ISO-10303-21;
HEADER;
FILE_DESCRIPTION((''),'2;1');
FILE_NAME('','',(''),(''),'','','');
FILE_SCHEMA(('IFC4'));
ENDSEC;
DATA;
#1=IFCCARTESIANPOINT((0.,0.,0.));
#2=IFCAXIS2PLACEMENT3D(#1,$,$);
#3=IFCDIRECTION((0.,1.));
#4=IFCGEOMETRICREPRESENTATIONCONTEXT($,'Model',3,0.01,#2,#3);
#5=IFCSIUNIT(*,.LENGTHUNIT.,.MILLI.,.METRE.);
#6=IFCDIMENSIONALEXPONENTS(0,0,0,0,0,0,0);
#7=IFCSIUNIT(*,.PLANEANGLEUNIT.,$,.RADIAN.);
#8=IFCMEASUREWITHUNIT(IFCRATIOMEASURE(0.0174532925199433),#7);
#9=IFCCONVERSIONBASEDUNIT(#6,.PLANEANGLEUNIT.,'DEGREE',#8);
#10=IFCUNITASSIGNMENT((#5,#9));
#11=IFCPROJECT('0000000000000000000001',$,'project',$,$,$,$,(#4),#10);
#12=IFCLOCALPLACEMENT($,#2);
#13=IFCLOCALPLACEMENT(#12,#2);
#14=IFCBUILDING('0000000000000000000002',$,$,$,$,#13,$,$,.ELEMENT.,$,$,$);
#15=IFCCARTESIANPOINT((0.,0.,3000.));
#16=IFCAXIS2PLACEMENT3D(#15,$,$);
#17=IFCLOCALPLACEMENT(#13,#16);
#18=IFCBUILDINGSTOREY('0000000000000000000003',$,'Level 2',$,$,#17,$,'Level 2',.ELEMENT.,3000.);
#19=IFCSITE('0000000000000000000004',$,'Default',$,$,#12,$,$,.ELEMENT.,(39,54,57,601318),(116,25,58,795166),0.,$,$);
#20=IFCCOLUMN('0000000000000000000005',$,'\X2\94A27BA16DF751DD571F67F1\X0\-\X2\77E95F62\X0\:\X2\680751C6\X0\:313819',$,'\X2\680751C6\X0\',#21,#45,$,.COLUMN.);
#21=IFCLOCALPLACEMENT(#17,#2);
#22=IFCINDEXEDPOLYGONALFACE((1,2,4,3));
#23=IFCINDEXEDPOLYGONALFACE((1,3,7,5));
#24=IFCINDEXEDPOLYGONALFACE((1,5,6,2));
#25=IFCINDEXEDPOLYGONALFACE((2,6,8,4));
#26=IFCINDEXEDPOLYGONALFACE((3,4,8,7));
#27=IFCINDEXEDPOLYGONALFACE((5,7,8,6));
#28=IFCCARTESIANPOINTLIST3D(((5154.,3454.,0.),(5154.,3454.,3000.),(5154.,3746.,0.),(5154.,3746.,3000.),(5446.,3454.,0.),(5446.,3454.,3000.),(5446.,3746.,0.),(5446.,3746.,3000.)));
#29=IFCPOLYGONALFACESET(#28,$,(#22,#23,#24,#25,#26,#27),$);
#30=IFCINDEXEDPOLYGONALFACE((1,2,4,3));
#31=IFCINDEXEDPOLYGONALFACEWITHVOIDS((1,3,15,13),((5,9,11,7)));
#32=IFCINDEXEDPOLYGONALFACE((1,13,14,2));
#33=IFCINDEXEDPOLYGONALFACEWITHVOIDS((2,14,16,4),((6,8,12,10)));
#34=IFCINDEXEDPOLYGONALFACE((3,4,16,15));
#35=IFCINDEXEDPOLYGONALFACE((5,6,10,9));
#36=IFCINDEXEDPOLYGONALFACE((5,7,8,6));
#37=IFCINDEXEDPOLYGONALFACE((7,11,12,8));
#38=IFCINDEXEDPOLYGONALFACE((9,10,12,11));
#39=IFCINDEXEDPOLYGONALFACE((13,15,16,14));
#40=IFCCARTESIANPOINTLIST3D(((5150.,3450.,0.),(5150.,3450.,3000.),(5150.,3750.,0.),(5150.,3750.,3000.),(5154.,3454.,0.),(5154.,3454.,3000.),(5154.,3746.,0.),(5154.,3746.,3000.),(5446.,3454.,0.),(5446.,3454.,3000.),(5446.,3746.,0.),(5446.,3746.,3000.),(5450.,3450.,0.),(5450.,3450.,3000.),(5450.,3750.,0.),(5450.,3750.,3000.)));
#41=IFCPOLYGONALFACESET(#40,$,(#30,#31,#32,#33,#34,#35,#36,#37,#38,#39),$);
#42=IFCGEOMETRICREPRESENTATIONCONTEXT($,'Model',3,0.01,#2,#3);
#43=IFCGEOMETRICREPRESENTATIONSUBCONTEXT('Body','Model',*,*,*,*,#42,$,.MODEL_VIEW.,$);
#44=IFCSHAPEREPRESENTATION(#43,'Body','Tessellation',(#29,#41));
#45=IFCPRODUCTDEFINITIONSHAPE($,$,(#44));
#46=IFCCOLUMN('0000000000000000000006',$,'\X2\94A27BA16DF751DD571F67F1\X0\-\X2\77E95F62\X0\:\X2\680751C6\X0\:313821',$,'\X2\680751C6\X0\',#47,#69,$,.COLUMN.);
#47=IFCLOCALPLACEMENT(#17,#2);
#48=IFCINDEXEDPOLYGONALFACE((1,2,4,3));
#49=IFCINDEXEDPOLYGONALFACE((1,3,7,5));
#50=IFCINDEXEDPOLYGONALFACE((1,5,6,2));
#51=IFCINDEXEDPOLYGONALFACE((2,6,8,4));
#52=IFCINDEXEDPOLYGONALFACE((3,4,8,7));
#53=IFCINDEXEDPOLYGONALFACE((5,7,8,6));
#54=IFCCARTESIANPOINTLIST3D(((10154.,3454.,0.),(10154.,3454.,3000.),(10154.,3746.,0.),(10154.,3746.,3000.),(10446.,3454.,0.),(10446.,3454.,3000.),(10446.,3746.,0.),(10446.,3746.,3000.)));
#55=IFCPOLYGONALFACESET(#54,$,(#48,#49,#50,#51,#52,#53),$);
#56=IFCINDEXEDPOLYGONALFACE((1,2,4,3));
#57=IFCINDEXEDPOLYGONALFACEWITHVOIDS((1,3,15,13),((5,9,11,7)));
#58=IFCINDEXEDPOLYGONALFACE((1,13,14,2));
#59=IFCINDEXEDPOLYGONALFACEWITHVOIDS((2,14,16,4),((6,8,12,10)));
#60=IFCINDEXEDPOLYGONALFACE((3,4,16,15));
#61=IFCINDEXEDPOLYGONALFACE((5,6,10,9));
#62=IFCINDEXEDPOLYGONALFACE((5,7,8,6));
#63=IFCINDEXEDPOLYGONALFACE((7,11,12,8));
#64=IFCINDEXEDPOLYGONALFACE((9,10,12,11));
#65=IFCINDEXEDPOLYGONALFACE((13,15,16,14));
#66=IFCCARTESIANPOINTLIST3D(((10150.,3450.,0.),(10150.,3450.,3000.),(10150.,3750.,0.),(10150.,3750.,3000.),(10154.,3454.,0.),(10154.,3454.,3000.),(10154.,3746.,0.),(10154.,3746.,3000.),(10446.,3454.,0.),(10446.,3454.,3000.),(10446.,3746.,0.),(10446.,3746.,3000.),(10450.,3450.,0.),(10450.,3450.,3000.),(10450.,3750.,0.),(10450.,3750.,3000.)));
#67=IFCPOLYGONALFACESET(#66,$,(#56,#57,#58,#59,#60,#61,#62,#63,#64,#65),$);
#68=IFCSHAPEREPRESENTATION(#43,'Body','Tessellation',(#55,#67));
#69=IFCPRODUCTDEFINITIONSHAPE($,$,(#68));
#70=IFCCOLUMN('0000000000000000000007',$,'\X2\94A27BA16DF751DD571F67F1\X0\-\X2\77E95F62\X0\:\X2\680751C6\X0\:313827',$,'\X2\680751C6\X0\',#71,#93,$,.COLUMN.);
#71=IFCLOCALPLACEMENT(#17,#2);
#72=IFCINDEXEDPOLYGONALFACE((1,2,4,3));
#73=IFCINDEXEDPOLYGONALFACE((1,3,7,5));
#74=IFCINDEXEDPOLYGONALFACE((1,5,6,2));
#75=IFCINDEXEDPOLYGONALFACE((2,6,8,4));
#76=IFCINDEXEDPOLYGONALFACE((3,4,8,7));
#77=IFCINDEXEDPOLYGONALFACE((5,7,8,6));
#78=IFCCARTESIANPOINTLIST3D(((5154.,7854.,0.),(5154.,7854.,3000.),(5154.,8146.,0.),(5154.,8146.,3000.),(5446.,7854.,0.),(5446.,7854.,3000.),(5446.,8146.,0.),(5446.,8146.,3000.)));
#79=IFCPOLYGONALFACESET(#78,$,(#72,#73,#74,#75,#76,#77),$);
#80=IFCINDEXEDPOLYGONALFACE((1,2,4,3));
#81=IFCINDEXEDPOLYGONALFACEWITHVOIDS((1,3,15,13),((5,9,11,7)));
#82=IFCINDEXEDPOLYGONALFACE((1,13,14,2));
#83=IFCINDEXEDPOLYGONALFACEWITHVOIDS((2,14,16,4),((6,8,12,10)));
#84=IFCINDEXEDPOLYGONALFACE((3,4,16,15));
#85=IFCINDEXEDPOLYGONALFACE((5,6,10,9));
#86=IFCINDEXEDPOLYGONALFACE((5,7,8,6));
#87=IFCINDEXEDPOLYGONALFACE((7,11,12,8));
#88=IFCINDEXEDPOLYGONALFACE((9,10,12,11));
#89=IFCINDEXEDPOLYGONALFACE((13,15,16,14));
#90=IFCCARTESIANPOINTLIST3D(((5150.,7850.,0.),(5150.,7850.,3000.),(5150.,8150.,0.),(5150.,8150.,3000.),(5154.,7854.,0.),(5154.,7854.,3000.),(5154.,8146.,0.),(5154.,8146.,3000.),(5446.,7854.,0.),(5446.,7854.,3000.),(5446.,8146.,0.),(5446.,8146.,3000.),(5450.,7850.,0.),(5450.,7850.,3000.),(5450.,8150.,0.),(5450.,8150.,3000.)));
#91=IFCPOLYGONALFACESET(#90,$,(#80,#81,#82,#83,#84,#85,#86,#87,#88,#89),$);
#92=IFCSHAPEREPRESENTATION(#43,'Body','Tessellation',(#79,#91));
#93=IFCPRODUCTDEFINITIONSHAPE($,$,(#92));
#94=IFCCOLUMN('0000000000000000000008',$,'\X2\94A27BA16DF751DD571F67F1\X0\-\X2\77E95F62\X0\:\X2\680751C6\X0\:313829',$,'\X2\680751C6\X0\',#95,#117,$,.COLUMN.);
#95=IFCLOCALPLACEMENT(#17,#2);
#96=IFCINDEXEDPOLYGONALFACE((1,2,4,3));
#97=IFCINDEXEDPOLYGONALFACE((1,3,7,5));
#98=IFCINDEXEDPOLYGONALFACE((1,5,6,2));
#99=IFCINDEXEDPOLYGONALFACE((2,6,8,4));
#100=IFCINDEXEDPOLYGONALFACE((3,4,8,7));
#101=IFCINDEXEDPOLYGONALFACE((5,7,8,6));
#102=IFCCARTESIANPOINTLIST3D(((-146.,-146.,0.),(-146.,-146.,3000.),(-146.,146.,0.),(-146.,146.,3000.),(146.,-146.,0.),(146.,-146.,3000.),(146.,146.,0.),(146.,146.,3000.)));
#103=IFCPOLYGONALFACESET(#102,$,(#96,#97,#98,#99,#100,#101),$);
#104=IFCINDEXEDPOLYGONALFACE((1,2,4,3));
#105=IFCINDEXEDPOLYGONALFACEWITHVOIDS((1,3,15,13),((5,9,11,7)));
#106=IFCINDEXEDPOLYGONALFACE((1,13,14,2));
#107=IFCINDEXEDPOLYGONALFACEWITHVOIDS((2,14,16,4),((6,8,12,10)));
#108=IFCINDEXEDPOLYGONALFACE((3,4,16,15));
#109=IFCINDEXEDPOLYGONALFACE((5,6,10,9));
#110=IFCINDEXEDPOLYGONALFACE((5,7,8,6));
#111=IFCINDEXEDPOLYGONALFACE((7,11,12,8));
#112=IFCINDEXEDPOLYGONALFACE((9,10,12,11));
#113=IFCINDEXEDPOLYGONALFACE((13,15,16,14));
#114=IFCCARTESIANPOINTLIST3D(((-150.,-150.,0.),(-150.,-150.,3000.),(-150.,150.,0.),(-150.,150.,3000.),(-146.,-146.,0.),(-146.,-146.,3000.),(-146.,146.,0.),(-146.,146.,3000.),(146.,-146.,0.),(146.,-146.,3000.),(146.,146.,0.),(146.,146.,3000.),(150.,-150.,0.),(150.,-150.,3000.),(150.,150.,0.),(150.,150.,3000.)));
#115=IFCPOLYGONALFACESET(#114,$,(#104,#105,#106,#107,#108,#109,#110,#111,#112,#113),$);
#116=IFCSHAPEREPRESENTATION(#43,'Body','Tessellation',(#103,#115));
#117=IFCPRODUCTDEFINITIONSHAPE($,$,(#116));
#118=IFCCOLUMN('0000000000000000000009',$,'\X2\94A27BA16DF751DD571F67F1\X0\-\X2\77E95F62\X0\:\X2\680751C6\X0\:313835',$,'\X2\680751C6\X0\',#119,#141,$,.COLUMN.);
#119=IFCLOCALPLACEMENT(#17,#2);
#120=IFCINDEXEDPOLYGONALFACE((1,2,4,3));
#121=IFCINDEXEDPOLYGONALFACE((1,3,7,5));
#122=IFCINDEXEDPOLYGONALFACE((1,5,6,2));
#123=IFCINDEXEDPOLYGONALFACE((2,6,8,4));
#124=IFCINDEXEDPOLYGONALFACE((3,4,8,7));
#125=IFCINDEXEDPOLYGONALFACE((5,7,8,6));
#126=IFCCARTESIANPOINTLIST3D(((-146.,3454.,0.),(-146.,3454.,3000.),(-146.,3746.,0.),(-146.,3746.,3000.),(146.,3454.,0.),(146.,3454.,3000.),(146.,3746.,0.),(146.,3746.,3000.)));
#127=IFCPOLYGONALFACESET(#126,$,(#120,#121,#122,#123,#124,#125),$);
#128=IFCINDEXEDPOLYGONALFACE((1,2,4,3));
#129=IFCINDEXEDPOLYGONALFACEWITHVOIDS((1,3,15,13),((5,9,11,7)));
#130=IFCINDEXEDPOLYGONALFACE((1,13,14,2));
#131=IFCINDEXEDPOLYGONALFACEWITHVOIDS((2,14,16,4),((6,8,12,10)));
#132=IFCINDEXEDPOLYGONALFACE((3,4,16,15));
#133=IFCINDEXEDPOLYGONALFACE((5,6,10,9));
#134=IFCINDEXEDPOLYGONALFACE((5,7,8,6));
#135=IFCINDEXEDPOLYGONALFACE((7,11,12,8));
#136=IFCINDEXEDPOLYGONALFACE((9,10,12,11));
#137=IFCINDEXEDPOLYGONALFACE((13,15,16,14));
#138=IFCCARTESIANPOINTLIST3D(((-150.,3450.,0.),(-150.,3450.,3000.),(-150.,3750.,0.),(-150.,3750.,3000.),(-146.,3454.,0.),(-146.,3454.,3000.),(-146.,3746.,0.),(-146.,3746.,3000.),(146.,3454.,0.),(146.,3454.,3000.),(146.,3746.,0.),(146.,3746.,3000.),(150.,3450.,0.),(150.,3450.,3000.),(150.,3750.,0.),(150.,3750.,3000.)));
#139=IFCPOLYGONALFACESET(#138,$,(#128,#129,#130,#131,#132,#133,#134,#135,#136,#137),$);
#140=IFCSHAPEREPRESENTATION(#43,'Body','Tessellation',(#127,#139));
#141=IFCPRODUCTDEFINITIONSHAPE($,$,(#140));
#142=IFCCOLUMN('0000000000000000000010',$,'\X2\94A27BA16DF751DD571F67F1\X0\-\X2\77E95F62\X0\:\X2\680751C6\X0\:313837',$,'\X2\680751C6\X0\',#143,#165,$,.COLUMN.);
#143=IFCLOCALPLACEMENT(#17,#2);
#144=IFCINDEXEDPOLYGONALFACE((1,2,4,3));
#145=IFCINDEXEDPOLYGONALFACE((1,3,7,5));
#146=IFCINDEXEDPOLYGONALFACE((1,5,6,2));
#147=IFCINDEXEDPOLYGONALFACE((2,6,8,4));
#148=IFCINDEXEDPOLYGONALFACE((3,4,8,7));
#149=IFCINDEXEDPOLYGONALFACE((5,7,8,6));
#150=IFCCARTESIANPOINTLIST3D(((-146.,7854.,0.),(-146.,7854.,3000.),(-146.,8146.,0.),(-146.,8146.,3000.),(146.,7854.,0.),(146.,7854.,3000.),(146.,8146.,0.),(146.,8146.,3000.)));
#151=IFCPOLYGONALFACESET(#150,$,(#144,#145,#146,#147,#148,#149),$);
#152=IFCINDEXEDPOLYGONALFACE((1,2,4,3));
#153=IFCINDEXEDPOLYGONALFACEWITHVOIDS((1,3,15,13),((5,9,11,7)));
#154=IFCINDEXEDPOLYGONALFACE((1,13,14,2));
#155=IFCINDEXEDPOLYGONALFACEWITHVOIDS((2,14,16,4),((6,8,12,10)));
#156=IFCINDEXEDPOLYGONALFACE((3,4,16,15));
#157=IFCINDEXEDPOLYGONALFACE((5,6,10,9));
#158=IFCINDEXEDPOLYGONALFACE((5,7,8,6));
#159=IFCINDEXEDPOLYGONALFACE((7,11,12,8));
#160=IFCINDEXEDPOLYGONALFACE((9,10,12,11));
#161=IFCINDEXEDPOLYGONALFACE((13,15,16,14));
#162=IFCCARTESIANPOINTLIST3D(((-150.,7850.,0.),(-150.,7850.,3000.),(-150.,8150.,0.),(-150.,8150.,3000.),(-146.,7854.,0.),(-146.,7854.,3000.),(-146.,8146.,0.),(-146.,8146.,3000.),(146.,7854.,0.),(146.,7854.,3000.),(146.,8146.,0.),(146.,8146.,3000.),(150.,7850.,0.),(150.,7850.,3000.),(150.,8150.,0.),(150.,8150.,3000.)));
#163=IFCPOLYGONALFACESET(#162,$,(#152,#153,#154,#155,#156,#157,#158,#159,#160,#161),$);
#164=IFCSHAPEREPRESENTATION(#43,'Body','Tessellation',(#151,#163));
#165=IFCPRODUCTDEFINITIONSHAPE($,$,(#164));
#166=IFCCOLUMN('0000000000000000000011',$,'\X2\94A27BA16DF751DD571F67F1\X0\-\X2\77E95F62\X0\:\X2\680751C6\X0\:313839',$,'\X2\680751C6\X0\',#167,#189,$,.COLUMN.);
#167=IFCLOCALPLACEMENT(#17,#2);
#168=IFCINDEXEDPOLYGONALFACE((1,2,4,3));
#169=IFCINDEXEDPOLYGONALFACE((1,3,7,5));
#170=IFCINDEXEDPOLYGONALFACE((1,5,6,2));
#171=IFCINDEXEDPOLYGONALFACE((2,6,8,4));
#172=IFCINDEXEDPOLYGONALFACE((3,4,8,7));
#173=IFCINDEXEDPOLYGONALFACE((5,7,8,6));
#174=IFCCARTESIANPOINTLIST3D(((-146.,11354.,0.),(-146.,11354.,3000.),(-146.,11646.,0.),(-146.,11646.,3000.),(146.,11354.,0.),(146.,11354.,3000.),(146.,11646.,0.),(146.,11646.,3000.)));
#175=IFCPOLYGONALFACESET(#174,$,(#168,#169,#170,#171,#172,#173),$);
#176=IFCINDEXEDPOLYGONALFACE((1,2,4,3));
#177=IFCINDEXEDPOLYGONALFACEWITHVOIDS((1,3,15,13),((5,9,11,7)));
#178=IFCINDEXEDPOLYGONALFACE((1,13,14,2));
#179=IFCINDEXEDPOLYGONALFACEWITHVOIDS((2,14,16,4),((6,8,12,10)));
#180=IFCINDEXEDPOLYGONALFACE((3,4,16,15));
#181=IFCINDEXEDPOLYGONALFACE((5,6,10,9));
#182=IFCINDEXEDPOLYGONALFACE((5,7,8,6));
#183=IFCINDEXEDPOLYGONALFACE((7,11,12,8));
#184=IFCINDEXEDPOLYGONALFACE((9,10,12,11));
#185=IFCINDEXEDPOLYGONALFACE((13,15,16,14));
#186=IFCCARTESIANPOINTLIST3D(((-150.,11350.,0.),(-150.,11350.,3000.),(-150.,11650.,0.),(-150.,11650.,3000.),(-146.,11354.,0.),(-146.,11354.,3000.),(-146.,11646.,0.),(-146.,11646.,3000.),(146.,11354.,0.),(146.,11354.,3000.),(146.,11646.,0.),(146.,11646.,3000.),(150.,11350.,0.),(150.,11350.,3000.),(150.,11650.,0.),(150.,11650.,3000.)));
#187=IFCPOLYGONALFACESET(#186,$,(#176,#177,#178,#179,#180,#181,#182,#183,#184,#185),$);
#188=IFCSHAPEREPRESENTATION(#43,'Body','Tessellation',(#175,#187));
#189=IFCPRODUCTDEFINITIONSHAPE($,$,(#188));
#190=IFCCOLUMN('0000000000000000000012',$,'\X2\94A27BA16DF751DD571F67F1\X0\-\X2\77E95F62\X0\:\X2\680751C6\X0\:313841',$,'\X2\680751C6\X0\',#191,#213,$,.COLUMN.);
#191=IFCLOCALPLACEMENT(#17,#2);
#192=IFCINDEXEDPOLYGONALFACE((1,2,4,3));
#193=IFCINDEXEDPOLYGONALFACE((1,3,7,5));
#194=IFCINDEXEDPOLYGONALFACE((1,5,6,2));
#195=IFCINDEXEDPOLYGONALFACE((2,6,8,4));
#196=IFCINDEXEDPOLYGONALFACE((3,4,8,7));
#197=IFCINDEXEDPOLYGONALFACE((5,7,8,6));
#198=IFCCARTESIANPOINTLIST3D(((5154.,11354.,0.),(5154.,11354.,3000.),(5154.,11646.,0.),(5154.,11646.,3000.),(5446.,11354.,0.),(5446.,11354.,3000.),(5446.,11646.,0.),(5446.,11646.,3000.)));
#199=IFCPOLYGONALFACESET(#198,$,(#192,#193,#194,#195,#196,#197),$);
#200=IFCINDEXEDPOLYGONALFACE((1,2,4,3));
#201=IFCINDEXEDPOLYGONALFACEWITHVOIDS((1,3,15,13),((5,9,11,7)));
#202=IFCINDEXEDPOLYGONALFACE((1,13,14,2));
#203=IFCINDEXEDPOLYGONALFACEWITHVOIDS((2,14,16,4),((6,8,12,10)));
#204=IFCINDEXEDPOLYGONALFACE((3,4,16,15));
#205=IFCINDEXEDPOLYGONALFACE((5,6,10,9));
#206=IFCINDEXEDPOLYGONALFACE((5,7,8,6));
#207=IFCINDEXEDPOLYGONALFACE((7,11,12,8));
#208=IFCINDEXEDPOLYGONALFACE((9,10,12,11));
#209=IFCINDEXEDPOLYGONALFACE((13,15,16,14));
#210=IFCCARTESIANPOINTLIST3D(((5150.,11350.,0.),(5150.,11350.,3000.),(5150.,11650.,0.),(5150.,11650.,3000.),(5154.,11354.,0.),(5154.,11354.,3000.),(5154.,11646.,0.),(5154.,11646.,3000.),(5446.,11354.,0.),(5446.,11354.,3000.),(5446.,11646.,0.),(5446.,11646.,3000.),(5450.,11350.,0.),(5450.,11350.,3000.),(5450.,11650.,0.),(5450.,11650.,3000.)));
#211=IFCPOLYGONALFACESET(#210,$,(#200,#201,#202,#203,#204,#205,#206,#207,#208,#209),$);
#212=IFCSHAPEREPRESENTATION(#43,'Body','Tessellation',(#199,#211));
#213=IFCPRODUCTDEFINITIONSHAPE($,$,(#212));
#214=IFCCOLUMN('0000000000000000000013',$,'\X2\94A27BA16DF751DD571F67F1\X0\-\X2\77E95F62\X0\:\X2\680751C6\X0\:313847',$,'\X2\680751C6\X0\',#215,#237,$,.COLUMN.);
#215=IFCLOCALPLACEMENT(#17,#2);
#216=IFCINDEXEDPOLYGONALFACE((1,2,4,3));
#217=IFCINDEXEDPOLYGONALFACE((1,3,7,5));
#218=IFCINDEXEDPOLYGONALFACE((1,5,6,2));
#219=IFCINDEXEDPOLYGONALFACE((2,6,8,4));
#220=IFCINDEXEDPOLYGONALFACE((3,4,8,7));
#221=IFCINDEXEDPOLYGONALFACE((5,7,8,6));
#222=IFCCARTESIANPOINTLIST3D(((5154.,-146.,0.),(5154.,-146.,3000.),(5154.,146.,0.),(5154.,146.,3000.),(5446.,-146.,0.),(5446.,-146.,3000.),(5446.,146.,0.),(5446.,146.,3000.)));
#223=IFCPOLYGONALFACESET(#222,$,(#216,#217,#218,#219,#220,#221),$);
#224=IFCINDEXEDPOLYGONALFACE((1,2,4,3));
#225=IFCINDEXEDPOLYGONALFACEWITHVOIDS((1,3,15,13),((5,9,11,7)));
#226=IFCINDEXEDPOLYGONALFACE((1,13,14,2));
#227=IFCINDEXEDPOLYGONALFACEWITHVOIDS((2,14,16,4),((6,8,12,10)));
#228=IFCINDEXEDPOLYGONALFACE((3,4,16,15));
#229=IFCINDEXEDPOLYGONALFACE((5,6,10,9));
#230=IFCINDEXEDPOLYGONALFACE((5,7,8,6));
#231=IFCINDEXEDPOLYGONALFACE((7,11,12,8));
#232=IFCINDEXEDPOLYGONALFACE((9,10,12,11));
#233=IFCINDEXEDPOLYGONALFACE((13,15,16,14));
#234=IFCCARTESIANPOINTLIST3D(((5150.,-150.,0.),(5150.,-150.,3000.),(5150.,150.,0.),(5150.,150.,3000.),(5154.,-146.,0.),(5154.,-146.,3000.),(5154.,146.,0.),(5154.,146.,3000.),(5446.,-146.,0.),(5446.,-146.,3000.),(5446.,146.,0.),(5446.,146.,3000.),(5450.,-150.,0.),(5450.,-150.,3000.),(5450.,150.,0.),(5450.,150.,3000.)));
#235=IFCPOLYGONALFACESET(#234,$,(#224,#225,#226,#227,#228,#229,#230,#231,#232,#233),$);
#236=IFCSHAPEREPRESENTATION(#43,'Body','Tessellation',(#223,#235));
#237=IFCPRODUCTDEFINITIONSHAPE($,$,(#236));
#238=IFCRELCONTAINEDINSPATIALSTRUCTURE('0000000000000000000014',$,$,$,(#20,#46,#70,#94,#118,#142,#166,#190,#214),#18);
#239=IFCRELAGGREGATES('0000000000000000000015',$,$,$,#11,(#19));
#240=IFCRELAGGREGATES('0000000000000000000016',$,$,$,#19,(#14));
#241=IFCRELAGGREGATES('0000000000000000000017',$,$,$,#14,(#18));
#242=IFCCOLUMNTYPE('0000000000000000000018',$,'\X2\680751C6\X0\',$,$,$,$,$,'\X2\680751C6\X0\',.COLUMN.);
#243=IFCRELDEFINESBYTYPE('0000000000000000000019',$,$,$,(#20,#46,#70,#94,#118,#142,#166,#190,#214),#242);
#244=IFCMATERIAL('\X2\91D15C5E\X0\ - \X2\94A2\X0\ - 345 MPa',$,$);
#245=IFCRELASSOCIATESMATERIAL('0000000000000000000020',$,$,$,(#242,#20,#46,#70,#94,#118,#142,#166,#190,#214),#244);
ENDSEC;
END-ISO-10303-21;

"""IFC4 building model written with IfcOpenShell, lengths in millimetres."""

from ifc_helpers import new_model, entity, si_unit, converted_unit, direction, frame, origin, origin_2d_with_axis, place, context, subcontext, project, spatial, polyline, rectangle, outline, extrude, source, transform, mapped, material, type_object, type_shapes, element, save


model = new_model("IFC4")

# Units and contexts
model_context_1 = context("Model", 3, precision=0.01, world=origin(), true_north=direction((0.0, 1.0)))
model_context_2 = context("Model", 3, precision=0.01, world=origin(), true_north=direction((0.0, 1.0)))
body_context_1 = subcontext(model_context_2, "Body", "Model", "MODEL_VIEW")
ifc_project = project(units=[si_unit("LENGTHUNIT", "METRE", prefix="MILLI"), converted_unit("PLANEANGLEUNIT", "DEGREE", entity("IfcRatioMeasure", 0.0174532925199433), si_unit("PLANEANGLEUNIT", "RADIAN"), dimensions=[0, 0, 0, 0, 0, 0, 0])], contexts=[model_context_1])

# Site, building, storey
site_placement = place(None, origin())
site = spatial("IfcSite", under=ifc_project, at=site_placement, Name="Default", CompositionType="ELEMENT", RefLatitude=(39, 54, 57, 601318), RefLongitude=(116, 25, 58, 795166), RefElevation=0.0)
building_placement = place(site_placement, origin())
building = spatial("IfcBuilding", under=site, at=building_placement, CompositionType="ELEMENT")
storey_placement = place(building_placement, frame((0.0, 0.0, 3000.0)))
storey = spatial("IfcBuildingStorey", under=building, at=storey_placement, Name="Level 2", LongName="Level 2", CompositionType="ELEMENT", Elevation=3000.0)

# Columns
ifc_material_1 = material(Name="金属 - 钢 - 345 MPa")
column_type = type_object("IfcColumnType", Name="标准", ElementType="标准", PredefinedType="COLUMN", material=ifc_material_1)
shared_shape_1 = source(origin(), body_context_1, "Body", "SweptSolid", [
    extrude(rectangle(XDim=292.0, YDim=292.0, at=origin_2d_with_axis()), frame((150.0, 150.0, 0.0), z_axis=(0.0, 0.0, 1.0), x_axis=(-1.0, 0.0, 0.0)), (0.0, 0.0, 1.0), 3000.0),
    extrude(outline(polyline([(-150.0, -150.0), (150.0, -150.0), (150.0, 150.0), (-150.0, 150.0), (-150.0, -150.0)]), holes=[polyline([(-146.0, -146.0), (-146.0, 146.0), (146.0, 146.0), (146.0, -146.0), (-146.0, -146.0)])]), frame((150.0, 150.0, 0.0), z_axis=(0.0, 0.0, 1.0), x_axis=(-1.0, 0.0, 0.0)), (0.0, 0.0, 1.0), 3000.0),
])
type_shapes(column_type, [shared_shape_1])
placement_1 = place(None, origin())
placement_2 = place(placement_1, origin())
placement_3 = place(placement_2, frame((0.0, 0.0, 3000.0)))
for number, where, name in (
    (1, (5150.0, 3450.0, 0.0), "钢管混凝土柱-矩形:标准:313819"),
    (2, (10150.0, 3450.0, 0.0), "钢管混凝土柱-矩形:标准:313821"),
    (3, (5150.0, 7850.0, 0.0), "钢管混凝土柱-矩形:标准:313827"),
    (4, (-150.0, -150.0, 0.0), "钢管混凝土柱-矩形:标准:313829"),
    (5, (-150.0, 3450.0, 0.0), "钢管混凝土柱-矩形:标准:313835"),
    (6, (-150.0, 7850.0, 0.0), "钢管混凝土柱-矩形:标准:313837"),
    (7, (-150.0, 11350.0, 0.0), "钢管混凝土柱-矩形:标准:313839"),
    (8, (5150.0, 11350.0, 0.0), "钢管混凝土柱-矩形:标准:313841"),
    (9, (5150.0, -150.0, 0.0), "钢管混凝土柱-矩形:标准:313847"),
):
    element("IfcColumn", number, at=place(placement_3, frame(where)), inside=storey, type_object=column_type, material=ifc_material_1, Name=name, ObjectType="标准", PredefinedType="COLUMN", context=body_context_1, shape_type="MappedRepresentation", body=[
        mapped(shared_shape_1, transform((0.0, 0.0, 0.0), scale=1.0)),
    ])

save(model, "model.ifc")
